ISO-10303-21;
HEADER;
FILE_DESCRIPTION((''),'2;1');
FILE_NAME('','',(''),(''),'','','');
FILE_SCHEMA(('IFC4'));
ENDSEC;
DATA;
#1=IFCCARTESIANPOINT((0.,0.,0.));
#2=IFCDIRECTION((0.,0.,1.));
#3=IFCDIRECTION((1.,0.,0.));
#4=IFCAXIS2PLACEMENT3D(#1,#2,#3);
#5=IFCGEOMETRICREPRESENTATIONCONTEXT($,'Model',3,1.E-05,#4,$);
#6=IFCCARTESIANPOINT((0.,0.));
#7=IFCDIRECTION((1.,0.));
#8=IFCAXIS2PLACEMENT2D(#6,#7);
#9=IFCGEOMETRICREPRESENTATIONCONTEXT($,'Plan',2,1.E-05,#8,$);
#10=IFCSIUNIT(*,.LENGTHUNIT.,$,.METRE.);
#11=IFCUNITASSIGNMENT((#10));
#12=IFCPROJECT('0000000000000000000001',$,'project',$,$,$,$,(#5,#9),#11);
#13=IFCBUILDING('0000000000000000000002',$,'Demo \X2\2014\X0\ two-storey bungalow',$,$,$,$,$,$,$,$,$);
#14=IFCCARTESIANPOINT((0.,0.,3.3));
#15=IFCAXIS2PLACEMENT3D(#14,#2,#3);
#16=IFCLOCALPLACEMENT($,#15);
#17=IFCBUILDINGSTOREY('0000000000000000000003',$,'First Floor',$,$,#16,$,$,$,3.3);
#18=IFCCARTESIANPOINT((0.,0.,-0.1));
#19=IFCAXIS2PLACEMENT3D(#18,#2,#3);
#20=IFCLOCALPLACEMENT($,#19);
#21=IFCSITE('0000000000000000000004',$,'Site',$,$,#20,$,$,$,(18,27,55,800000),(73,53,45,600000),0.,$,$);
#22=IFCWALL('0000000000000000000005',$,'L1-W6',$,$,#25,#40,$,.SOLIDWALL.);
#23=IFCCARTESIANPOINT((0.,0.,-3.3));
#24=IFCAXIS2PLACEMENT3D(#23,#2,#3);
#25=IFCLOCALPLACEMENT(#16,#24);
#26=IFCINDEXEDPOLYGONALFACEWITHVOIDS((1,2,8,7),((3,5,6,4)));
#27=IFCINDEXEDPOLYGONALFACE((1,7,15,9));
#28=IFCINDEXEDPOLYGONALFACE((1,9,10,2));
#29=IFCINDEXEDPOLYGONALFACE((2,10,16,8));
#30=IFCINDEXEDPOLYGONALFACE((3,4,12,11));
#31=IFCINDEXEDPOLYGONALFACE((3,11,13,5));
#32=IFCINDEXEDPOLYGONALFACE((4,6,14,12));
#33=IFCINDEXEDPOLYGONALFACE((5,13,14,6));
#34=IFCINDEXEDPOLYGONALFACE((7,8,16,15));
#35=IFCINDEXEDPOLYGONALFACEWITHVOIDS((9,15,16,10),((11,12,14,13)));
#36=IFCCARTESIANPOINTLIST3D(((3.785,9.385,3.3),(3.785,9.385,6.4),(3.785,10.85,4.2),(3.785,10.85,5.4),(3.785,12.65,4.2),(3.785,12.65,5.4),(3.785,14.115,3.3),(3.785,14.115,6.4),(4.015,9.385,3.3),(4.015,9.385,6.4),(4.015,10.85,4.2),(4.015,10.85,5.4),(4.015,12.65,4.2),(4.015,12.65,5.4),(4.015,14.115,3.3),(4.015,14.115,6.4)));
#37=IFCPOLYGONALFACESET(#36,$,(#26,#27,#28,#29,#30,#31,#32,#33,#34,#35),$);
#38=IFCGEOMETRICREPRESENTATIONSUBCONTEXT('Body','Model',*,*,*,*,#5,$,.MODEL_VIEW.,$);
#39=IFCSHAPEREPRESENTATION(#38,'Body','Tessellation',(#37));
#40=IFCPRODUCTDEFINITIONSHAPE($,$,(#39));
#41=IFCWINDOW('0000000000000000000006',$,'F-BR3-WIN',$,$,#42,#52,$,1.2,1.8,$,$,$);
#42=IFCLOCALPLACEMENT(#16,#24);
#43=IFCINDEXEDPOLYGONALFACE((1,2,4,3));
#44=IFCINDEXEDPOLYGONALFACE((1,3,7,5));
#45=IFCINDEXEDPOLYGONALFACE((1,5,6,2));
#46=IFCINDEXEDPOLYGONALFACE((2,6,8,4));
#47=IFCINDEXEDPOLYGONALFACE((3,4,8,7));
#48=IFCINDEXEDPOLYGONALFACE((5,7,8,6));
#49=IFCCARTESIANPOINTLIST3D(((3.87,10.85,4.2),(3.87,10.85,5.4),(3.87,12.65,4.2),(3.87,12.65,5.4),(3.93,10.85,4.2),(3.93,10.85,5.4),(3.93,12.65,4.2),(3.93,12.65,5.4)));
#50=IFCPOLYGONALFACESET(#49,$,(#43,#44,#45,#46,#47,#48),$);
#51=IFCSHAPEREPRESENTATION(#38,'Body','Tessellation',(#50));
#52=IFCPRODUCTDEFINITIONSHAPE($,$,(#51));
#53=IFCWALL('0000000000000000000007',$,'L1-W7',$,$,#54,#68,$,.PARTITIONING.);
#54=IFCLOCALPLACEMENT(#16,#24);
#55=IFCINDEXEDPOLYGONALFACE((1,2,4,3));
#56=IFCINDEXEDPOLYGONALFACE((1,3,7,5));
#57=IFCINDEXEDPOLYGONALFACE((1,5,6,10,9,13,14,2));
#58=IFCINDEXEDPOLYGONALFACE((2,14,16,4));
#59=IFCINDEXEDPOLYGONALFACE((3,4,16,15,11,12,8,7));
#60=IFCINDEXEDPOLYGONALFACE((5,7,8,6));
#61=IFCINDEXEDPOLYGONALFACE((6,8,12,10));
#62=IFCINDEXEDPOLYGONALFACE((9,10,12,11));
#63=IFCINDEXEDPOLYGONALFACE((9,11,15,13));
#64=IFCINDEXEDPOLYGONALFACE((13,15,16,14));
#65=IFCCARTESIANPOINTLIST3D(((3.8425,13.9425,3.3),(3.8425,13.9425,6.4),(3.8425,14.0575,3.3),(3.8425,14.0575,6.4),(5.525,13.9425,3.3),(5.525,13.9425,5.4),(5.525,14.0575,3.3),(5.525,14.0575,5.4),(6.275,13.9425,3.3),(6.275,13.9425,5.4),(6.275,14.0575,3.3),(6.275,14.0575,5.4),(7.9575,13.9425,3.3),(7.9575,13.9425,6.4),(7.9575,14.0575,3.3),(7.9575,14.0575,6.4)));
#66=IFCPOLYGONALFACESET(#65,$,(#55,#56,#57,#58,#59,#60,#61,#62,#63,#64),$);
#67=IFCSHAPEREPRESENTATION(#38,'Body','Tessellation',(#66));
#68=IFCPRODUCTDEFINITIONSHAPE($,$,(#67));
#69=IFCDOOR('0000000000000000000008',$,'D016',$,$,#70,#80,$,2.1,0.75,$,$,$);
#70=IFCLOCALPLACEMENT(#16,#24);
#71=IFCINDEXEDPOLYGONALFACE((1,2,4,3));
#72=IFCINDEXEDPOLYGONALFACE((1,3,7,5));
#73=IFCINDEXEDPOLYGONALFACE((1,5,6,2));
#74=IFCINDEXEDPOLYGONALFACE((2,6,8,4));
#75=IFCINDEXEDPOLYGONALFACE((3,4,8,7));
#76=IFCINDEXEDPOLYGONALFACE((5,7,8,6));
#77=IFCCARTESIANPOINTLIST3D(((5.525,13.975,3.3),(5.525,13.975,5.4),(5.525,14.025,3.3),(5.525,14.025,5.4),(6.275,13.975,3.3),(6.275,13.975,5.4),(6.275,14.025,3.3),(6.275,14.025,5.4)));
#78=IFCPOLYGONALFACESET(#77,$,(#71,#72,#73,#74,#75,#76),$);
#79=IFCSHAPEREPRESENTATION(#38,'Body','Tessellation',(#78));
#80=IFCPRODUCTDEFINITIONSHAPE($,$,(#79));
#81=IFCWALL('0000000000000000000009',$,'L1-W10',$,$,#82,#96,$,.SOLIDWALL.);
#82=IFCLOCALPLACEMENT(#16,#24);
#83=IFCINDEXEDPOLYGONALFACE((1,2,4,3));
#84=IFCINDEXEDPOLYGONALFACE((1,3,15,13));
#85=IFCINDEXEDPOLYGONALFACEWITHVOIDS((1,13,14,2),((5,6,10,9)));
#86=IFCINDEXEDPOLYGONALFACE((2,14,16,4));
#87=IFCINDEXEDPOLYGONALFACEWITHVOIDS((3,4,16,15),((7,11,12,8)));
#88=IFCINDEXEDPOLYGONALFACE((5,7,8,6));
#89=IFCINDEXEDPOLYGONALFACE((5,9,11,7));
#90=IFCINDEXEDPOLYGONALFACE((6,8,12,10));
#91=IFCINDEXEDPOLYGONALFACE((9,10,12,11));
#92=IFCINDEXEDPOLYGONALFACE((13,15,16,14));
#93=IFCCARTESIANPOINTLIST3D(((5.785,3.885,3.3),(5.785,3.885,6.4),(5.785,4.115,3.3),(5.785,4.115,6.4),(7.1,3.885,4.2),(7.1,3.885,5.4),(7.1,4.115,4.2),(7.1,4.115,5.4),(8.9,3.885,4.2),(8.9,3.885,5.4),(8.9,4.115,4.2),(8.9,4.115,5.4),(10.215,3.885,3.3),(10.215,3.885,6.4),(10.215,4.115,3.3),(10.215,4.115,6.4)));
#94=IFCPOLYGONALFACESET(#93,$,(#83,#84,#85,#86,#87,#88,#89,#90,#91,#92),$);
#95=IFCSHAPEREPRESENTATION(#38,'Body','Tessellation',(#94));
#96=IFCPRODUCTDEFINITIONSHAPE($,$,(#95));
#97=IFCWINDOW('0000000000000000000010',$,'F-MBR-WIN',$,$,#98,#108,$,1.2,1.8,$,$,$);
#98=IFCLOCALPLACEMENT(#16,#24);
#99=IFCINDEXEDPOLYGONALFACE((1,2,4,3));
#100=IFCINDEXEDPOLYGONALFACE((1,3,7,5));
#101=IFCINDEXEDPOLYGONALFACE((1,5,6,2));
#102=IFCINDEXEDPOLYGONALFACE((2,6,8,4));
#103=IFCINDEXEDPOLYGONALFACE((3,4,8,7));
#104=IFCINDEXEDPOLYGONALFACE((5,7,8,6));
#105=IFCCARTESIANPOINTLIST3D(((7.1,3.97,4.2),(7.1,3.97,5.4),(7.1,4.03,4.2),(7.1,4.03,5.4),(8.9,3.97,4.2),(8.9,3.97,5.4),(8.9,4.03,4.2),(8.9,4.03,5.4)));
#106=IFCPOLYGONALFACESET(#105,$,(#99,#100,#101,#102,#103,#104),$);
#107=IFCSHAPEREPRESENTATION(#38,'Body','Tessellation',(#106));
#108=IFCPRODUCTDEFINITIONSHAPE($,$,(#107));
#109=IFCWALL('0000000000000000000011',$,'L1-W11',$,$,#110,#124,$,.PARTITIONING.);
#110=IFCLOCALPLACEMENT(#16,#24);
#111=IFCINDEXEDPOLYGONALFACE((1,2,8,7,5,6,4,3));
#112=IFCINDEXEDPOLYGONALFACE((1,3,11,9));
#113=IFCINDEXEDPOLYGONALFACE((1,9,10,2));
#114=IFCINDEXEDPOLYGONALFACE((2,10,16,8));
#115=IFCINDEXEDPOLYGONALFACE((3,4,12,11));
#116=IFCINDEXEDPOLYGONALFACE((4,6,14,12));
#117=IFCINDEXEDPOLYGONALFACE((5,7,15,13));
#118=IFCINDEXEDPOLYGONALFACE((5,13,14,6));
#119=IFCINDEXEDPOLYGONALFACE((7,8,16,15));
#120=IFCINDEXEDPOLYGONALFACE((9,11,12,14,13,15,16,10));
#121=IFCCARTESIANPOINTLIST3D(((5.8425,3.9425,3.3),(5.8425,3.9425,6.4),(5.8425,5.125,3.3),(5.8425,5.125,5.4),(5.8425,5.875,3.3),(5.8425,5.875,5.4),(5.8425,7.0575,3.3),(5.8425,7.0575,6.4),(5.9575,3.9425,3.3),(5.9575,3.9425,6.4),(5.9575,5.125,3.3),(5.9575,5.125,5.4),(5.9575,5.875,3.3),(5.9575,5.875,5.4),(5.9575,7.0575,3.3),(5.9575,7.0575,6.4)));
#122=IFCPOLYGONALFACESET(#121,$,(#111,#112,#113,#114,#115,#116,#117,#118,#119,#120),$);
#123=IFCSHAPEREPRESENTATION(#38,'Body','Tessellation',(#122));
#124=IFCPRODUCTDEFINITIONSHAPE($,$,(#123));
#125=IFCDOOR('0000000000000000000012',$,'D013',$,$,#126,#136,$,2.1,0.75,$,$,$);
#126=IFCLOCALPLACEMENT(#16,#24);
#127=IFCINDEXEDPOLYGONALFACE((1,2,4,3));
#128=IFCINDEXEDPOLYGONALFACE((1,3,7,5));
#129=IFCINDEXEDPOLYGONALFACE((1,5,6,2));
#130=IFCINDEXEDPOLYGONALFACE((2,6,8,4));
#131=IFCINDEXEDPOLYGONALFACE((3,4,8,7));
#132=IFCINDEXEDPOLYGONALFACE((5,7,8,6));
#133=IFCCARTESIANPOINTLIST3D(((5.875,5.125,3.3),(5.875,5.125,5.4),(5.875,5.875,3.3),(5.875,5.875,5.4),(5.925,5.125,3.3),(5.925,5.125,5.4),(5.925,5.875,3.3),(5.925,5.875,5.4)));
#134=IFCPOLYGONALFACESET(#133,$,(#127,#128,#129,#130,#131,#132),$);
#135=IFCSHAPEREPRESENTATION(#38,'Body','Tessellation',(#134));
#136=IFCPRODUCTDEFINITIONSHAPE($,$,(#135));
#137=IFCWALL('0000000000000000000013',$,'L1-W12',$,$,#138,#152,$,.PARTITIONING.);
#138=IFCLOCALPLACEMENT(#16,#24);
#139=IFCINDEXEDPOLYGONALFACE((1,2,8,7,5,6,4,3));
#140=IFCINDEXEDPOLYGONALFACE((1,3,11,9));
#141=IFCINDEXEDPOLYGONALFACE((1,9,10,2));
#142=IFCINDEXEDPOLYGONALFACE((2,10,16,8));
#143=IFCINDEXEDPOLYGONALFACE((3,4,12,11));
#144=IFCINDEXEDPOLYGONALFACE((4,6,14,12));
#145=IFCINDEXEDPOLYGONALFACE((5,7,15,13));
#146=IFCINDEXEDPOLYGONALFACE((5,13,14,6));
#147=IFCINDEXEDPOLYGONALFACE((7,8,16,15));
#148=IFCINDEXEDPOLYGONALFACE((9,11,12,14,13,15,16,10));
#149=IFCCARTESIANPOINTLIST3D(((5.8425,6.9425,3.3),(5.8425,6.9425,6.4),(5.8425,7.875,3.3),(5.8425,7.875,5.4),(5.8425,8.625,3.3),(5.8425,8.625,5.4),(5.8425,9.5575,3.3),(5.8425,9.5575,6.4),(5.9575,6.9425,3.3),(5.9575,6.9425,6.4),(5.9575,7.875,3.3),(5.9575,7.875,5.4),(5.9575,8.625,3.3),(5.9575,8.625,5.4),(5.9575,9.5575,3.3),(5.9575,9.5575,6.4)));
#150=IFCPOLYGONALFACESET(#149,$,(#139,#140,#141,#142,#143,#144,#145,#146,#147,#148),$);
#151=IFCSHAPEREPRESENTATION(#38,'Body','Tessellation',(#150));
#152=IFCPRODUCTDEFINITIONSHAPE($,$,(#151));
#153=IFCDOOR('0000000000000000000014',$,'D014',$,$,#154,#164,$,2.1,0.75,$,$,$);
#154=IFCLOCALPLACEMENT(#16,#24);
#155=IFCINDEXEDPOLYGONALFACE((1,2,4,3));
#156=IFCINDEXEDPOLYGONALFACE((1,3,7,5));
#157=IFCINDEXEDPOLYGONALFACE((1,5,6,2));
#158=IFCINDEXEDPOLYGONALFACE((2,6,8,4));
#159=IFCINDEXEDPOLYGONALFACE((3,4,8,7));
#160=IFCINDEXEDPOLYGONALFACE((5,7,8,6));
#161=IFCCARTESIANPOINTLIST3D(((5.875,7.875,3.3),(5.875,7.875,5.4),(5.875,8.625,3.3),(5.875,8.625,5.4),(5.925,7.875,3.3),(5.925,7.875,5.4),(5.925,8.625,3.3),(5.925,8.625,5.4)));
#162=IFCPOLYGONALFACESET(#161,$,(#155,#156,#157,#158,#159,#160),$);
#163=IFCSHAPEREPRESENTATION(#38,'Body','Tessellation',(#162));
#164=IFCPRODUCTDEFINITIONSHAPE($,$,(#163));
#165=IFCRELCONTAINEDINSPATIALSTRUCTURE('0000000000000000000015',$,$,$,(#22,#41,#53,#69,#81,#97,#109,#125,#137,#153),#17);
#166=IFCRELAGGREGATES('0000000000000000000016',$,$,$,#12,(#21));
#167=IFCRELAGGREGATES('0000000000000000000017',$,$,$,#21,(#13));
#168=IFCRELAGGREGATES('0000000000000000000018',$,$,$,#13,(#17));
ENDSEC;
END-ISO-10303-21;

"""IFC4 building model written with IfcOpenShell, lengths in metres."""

from ifc_helpers import new_model, si_unit, frame, origin_with_axes, origin_2d_with_axis, place, context, subcontext, project, spatial, line, indexed_curve, outline, extrude, element, fill, save


model = new_model("IFC4")

# Units and contexts
model_context = context("Model", 3, precision=1e-05, world=origin_with_axes())
plan_context = context("Plan", 2, precision=1e-05, world=origin_2d_with_axis())
body_context = subcontext(model_context, "Body", "Model", "MODEL_VIEW")
ifc_project = project(units=[si_unit("LENGTHUNIT", "METRE")], contexts=[model_context, plan_context])

# Site, building, storey
site_placement = place(None, frame((0.0, 0.0, -0.1), z_axis=(0.0, 0.0, 1.0), x_axis=(1.0, 0.0, 0.0)))
site = spatial("IfcSite", under=ifc_project, at=site_placement, Name="Site", RefLatitude=(18, 27, 55, 800000), RefLongitude=(73, 53, 45, 600000), RefElevation=0.0)
building = spatial("IfcBuilding", under=site, Name="Demo — two-storey bungalow")
storey_placement = place(None, frame((0.0, 0.0, 3.3), z_axis=(0.0, 0.0, 1.0), x_axis=(1.0, 0.0, 0.0)))
storey = spatial("IfcBuildingStorey", under=building, at=storey_placement, Name="First Floor", Elevation=3.3)

# Wall, opening, window
wall_1_placement = place(storey_placement, frame((0.0, 0.0, -3.3), z_axis=(0.0, 0.0, 1.0), x_axis=(1.0, 0.0, 0.0)))
wall_1 = element("IfcWall", 1, at=wall_1_placement, inside=storey, Name="L1-W6", PredefinedType="SOLIDWALL", context=body_context, shape_type="SweptSolid", body=[
    extrude(outline(indexed_curve([(4.015, 14.115), (4.015, 9.385), (3.785, 9.385), (3.785, 14.115)], segments=[line(1, 2, 3, 4, 1)])), frame((0.0, 0.0, 3.3), z_axis=(0.0, 0.0, 1.0), x_axis=(1.0, 0.0, 0.0)), (0.0, 0.0, 1.0), 3.1),
])
opening_1_placement = place(wall_1_placement, origin_with_axes())
opening_1 = element("IfcOpeningElement", 2, at=opening_1_placement, cuts=wall_1, context=body_context, shape_type="SweptSolid", body=[
    extrude(outline(indexed_curve([(4.065, 12.65), (4.065, 10.85), (3.735, 10.85), (3.735, 12.65)], segments=[line(1, 2, 3, 4, 1)])), frame((0.0, 0.0, 4.2), z_axis=(0.0, 0.0, 1.0), x_axis=(1.0, 0.0, 0.0)), (0.0, 0.0, 1.0), 1.2),
])
window_1_placement = place(storey_placement, frame((0.0, 0.0, -3.3), z_axis=(0.0, 0.0, 1.0), x_axis=(1.0, 0.0, 0.0)))
window_1 = element("IfcWindow", 3, at=window_1_placement, inside=storey, Name="F-BR3-WIN", OverallHeight=1.2, OverallWidth=1.8, context=body_context, shape_type="SweptSolid", body=[
    extrude(outline(indexed_curve([(3.93, 12.65), (3.93, 10.85), (3.87, 10.85), (3.87, 12.65)], segments=[line(1, 2, 3, 4, 1)])), frame((0.0, 0.0, 4.2), z_axis=(0.0, 0.0, 1.0), x_axis=(1.0, 0.0, 0.0)), (0.0, 0.0, 1.0), 1.2),
])
fill(opening_1, window_1)

# Wall, opening, door
wall_2_placement = place(storey_placement, frame((0.0, 0.0, -3.3), z_axis=(0.0, 0.0, 1.0), x_axis=(1.0, 0.0, 0.0)))
wall_2 = element("IfcWall", 4, at=wall_2_placement, inside=storey, Name="L1-W7", PredefinedType="PARTITIONING", context=body_context, shape_type="SweptSolid", body=[
    extrude(outline(indexed_curve([(7.9575, 13.9425), (3.8425, 13.9425), (3.8425, 14.0575), (7.9575, 14.0575)], segments=[line(1, 2, 3, 4, 1)])), frame((0.0, 0.0, 3.3), z_axis=(0.0, 0.0, 1.0), x_axis=(1.0, 0.0, 0.0)), (0.0, 0.0, 1.0), 3.1),
])
opening_2_placement = place(wall_2_placement, origin_with_axes())
opening_2 = element("IfcOpeningElement", 5, at=opening_2_placement, cuts=wall_2, context=body_context, shape_type="SweptSolid", body=[
    extrude(outline(indexed_curve([(6.275, 13.8925), (5.525, 13.8925), (5.525, 14.1075), (6.275, 14.1075)], segments=[line(1, 2, 3, 4, 1)])), frame((0.0, 0.0, 3.3), z_axis=(0.0, 0.0, 1.0), x_axis=(1.0, 0.0, 0.0)), (0.0, 0.0, 1.0), 2.1),
])
door_1_placement = place(storey_placement, frame((0.0, 0.0, -3.3), z_axis=(0.0, 0.0, 1.0), x_axis=(1.0, 0.0, 0.0)))
door_1 = element("IfcDoor", 6, at=door_1_placement, inside=storey, Name="D016", OverallHeight=2.1, OverallWidth=0.75, context=body_context, shape_type="SweptSolid", body=[
    extrude(outline(indexed_curve([(6.275, 13.975), (5.525, 13.975), (5.525, 14.025), (6.275, 14.025)], segments=[line(1, 2, 3, 4, 1)])), frame((0.0, 0.0, 3.3), z_axis=(0.0, 0.0, 1.0), x_axis=(1.0, 0.0, 0.0)), (0.0, 0.0, 1.0), 2.1),
])
fill(opening_2, door_1)

# Wall, opening, window
wall_3_placement = place(storey_placement, frame((0.0, 0.0, -3.3), z_axis=(0.0, 0.0, 1.0), x_axis=(1.0, 0.0, 0.0)))
wall_3 = element("IfcWall", 7, at=wall_3_placement, inside=storey, Name="L1-W10", PredefinedType="SOLIDWALL", context=body_context, shape_type="SweptSolid", body=[
    extrude(outline(indexed_curve([(5.785, 4.115), (10.215, 4.115), (10.215, 3.885), (5.785, 3.885)], segments=[line(1, 2, 3, 4, 1)])), frame((0.0, 0.0, 3.3), z_axis=(0.0, 0.0, 1.0), x_axis=(1.0, 0.0, 0.0)), (0.0, 0.0, 1.0), 3.1),
])
opening_3_placement = place(wall_3_placement, origin_with_axes())
opening_3 = element("IfcOpeningElement", 8, at=opening_3_placement, cuts=wall_3, context=body_context, shape_type="SweptSolid", body=[
    extrude(outline(indexed_curve([(7.1, 4.165), (8.9, 4.165), (8.9, 3.835), (7.1, 3.835)], segments=[line(1, 2, 3, 4, 1)])), frame((0.0, 0.0, 4.2), z_axis=(0.0, 0.0, 1.0), x_axis=(1.0, 0.0, 0.0)), (0.0, 0.0, 1.0), 1.2),
])
window_2_placement = place(storey_placement, frame((0.0, 0.0, -3.3), z_axis=(0.0, 0.0, 1.0), x_axis=(1.0, 0.0, 0.0)))
window_2 = element("IfcWindow", 9, at=window_2_placement, inside=storey, Name="F-MBR-WIN", OverallHeight=1.2, OverallWidth=1.8, context=body_context, shape_type="SweptSolid", body=[
    extrude(outline(indexed_curve([(7.1, 4.03), (8.9, 4.03), (8.9, 3.97), (7.1, 3.97)], segments=[line(1, 2, 3, 4, 1)])), frame((0.0, 0.0, 4.2), z_axis=(0.0, 0.0, 1.0), x_axis=(1.0, 0.0, 0.0)), (0.0, 0.0, 1.0), 1.2),
])
fill(opening_3, window_2)

# Walls, openings, doors
wall_4_placement = place(storey_placement, frame((0.0, 0.0, -3.3), z_axis=(0.0, 0.0, 1.0), x_axis=(1.0, 0.0, 0.0)))
wall_4 = element("IfcWall", 10, at=wall_4_placement, inside=storey, Name="L1-W11", PredefinedType="PARTITIONING", context=body_context, shape_type="SweptSolid", body=[
    extrude(outline(indexed_curve([(5.9575, 7.0575), (5.9575, 3.9425), (5.8425, 3.9425), (5.8425, 7.0575)], segments=[line(1, 2, 3, 4, 1)])), frame((0.0, 0.0, 3.3), z_axis=(0.0, 0.0, 1.0), x_axis=(1.0, 0.0, 0.0)), (0.0, 0.0, 1.0), 3.1),
])
opening_4_placement = place(wall_4_placement, origin_with_axes())
opening_4 = element("IfcOpeningElement", 11, at=opening_4_placement, cuts=wall_4, context=body_context, shape_type="SweptSolid", body=[
    extrude(outline(indexed_curve([(6.0075, 5.875), (6.0075, 5.125), (5.7925, 5.125), (5.7925, 5.875)], segments=[line(1, 2, 3, 4, 1)])), frame((0.0, 0.0, 3.3), z_axis=(0.0, 0.0, 1.0), x_axis=(1.0, 0.0, 0.0)), (0.0, 0.0, 1.0), 2.1),
])
door_2_placement = place(storey_placement, frame((0.0, 0.0, -3.3), z_axis=(0.0, 0.0, 1.0), x_axis=(1.0, 0.0, 0.0)))
door_2 = element("IfcDoor", 12, at=door_2_placement, inside=storey, Name="D013", OverallHeight=2.1, OverallWidth=0.75, context=body_context, shape_type="SweptSolid", body=[
    extrude(outline(indexed_curve([(5.925, 5.875), (5.925, 5.125), (5.875, 5.125), (5.875, 5.875)], segments=[line(1, 2, 3, 4, 1)])), frame((0.0, 0.0, 3.3), z_axis=(0.0, 0.0, 1.0), x_axis=(1.0, 0.0, 0.0)), (0.0, 0.0, 1.0), 2.1),
])
fill(opening_4, door_2)
wall_5_placement = place(storey_placement, frame((0.0, 0.0, -3.3), z_axis=(0.0, 0.0, 1.0), x_axis=(1.0, 0.0, 0.0)))
wall_5 = element("IfcWall", 13, at=wall_5_placement, inside=storey, Name="L1-W12", PredefinedType="PARTITIONING", context=body_context, shape_type="SweptSolid", body=[
    extrude(outline(indexed_curve([(5.9575, 9.5575), (5.9575, 6.9425), (5.8425, 6.9425), (5.8425, 9.5575)], segments=[line(1, 2, 3, 4, 1)])), frame((0.0, 0.0, 3.3), z_axis=(0.0, 0.0, 1.0), x_axis=(1.0, 0.0, 0.0)), (0.0, 0.0, 1.0), 3.1),
])
opening_5_placement = place(wall_5_placement, origin_with_axes())
opening_5 = element("IfcOpeningElement", 14, at=opening_5_placement, cuts=wall_5, context=body_context, shape_type="SweptSolid", body=[
    extrude(outline(indexed_curve([(6.0075, 8.625), (6.0075, 7.875), (5.7925, 7.875), (5.7925, 8.625)], segments=[line(1, 2, 3, 4, 1)])), frame((0.0, 0.0, 3.3), z_axis=(0.0, 0.0, 1.0), x_axis=(1.0, 0.0, 0.0)), (0.0, 0.0, 1.0), 2.1),
])
door_3_placement = place(storey_placement, frame((0.0, 0.0, -3.3), z_axis=(0.0, 0.0, 1.0), x_axis=(1.0, 0.0, 0.0)))
door_3 = element("IfcDoor", 15, at=door_3_placement, inside=storey, Name="D014", OverallHeight=2.1, OverallWidth=0.75, context=body_context, shape_type="SweptSolid", body=[
    extrude(outline(indexed_curve([(5.925, 8.625), (5.925, 7.875), (5.875, 7.875), (5.875, 8.625)], segments=[line(1, 2, 3, 4, 1)])), frame((0.0, 0.0, 3.3), z_axis=(0.0, 0.0, 1.0), x_axis=(1.0, 0.0, 0.0)), (0.0, 0.0, 1.0), 2.1),
])
fill(opening_5, door_3)

save(model, "model.ifc")
